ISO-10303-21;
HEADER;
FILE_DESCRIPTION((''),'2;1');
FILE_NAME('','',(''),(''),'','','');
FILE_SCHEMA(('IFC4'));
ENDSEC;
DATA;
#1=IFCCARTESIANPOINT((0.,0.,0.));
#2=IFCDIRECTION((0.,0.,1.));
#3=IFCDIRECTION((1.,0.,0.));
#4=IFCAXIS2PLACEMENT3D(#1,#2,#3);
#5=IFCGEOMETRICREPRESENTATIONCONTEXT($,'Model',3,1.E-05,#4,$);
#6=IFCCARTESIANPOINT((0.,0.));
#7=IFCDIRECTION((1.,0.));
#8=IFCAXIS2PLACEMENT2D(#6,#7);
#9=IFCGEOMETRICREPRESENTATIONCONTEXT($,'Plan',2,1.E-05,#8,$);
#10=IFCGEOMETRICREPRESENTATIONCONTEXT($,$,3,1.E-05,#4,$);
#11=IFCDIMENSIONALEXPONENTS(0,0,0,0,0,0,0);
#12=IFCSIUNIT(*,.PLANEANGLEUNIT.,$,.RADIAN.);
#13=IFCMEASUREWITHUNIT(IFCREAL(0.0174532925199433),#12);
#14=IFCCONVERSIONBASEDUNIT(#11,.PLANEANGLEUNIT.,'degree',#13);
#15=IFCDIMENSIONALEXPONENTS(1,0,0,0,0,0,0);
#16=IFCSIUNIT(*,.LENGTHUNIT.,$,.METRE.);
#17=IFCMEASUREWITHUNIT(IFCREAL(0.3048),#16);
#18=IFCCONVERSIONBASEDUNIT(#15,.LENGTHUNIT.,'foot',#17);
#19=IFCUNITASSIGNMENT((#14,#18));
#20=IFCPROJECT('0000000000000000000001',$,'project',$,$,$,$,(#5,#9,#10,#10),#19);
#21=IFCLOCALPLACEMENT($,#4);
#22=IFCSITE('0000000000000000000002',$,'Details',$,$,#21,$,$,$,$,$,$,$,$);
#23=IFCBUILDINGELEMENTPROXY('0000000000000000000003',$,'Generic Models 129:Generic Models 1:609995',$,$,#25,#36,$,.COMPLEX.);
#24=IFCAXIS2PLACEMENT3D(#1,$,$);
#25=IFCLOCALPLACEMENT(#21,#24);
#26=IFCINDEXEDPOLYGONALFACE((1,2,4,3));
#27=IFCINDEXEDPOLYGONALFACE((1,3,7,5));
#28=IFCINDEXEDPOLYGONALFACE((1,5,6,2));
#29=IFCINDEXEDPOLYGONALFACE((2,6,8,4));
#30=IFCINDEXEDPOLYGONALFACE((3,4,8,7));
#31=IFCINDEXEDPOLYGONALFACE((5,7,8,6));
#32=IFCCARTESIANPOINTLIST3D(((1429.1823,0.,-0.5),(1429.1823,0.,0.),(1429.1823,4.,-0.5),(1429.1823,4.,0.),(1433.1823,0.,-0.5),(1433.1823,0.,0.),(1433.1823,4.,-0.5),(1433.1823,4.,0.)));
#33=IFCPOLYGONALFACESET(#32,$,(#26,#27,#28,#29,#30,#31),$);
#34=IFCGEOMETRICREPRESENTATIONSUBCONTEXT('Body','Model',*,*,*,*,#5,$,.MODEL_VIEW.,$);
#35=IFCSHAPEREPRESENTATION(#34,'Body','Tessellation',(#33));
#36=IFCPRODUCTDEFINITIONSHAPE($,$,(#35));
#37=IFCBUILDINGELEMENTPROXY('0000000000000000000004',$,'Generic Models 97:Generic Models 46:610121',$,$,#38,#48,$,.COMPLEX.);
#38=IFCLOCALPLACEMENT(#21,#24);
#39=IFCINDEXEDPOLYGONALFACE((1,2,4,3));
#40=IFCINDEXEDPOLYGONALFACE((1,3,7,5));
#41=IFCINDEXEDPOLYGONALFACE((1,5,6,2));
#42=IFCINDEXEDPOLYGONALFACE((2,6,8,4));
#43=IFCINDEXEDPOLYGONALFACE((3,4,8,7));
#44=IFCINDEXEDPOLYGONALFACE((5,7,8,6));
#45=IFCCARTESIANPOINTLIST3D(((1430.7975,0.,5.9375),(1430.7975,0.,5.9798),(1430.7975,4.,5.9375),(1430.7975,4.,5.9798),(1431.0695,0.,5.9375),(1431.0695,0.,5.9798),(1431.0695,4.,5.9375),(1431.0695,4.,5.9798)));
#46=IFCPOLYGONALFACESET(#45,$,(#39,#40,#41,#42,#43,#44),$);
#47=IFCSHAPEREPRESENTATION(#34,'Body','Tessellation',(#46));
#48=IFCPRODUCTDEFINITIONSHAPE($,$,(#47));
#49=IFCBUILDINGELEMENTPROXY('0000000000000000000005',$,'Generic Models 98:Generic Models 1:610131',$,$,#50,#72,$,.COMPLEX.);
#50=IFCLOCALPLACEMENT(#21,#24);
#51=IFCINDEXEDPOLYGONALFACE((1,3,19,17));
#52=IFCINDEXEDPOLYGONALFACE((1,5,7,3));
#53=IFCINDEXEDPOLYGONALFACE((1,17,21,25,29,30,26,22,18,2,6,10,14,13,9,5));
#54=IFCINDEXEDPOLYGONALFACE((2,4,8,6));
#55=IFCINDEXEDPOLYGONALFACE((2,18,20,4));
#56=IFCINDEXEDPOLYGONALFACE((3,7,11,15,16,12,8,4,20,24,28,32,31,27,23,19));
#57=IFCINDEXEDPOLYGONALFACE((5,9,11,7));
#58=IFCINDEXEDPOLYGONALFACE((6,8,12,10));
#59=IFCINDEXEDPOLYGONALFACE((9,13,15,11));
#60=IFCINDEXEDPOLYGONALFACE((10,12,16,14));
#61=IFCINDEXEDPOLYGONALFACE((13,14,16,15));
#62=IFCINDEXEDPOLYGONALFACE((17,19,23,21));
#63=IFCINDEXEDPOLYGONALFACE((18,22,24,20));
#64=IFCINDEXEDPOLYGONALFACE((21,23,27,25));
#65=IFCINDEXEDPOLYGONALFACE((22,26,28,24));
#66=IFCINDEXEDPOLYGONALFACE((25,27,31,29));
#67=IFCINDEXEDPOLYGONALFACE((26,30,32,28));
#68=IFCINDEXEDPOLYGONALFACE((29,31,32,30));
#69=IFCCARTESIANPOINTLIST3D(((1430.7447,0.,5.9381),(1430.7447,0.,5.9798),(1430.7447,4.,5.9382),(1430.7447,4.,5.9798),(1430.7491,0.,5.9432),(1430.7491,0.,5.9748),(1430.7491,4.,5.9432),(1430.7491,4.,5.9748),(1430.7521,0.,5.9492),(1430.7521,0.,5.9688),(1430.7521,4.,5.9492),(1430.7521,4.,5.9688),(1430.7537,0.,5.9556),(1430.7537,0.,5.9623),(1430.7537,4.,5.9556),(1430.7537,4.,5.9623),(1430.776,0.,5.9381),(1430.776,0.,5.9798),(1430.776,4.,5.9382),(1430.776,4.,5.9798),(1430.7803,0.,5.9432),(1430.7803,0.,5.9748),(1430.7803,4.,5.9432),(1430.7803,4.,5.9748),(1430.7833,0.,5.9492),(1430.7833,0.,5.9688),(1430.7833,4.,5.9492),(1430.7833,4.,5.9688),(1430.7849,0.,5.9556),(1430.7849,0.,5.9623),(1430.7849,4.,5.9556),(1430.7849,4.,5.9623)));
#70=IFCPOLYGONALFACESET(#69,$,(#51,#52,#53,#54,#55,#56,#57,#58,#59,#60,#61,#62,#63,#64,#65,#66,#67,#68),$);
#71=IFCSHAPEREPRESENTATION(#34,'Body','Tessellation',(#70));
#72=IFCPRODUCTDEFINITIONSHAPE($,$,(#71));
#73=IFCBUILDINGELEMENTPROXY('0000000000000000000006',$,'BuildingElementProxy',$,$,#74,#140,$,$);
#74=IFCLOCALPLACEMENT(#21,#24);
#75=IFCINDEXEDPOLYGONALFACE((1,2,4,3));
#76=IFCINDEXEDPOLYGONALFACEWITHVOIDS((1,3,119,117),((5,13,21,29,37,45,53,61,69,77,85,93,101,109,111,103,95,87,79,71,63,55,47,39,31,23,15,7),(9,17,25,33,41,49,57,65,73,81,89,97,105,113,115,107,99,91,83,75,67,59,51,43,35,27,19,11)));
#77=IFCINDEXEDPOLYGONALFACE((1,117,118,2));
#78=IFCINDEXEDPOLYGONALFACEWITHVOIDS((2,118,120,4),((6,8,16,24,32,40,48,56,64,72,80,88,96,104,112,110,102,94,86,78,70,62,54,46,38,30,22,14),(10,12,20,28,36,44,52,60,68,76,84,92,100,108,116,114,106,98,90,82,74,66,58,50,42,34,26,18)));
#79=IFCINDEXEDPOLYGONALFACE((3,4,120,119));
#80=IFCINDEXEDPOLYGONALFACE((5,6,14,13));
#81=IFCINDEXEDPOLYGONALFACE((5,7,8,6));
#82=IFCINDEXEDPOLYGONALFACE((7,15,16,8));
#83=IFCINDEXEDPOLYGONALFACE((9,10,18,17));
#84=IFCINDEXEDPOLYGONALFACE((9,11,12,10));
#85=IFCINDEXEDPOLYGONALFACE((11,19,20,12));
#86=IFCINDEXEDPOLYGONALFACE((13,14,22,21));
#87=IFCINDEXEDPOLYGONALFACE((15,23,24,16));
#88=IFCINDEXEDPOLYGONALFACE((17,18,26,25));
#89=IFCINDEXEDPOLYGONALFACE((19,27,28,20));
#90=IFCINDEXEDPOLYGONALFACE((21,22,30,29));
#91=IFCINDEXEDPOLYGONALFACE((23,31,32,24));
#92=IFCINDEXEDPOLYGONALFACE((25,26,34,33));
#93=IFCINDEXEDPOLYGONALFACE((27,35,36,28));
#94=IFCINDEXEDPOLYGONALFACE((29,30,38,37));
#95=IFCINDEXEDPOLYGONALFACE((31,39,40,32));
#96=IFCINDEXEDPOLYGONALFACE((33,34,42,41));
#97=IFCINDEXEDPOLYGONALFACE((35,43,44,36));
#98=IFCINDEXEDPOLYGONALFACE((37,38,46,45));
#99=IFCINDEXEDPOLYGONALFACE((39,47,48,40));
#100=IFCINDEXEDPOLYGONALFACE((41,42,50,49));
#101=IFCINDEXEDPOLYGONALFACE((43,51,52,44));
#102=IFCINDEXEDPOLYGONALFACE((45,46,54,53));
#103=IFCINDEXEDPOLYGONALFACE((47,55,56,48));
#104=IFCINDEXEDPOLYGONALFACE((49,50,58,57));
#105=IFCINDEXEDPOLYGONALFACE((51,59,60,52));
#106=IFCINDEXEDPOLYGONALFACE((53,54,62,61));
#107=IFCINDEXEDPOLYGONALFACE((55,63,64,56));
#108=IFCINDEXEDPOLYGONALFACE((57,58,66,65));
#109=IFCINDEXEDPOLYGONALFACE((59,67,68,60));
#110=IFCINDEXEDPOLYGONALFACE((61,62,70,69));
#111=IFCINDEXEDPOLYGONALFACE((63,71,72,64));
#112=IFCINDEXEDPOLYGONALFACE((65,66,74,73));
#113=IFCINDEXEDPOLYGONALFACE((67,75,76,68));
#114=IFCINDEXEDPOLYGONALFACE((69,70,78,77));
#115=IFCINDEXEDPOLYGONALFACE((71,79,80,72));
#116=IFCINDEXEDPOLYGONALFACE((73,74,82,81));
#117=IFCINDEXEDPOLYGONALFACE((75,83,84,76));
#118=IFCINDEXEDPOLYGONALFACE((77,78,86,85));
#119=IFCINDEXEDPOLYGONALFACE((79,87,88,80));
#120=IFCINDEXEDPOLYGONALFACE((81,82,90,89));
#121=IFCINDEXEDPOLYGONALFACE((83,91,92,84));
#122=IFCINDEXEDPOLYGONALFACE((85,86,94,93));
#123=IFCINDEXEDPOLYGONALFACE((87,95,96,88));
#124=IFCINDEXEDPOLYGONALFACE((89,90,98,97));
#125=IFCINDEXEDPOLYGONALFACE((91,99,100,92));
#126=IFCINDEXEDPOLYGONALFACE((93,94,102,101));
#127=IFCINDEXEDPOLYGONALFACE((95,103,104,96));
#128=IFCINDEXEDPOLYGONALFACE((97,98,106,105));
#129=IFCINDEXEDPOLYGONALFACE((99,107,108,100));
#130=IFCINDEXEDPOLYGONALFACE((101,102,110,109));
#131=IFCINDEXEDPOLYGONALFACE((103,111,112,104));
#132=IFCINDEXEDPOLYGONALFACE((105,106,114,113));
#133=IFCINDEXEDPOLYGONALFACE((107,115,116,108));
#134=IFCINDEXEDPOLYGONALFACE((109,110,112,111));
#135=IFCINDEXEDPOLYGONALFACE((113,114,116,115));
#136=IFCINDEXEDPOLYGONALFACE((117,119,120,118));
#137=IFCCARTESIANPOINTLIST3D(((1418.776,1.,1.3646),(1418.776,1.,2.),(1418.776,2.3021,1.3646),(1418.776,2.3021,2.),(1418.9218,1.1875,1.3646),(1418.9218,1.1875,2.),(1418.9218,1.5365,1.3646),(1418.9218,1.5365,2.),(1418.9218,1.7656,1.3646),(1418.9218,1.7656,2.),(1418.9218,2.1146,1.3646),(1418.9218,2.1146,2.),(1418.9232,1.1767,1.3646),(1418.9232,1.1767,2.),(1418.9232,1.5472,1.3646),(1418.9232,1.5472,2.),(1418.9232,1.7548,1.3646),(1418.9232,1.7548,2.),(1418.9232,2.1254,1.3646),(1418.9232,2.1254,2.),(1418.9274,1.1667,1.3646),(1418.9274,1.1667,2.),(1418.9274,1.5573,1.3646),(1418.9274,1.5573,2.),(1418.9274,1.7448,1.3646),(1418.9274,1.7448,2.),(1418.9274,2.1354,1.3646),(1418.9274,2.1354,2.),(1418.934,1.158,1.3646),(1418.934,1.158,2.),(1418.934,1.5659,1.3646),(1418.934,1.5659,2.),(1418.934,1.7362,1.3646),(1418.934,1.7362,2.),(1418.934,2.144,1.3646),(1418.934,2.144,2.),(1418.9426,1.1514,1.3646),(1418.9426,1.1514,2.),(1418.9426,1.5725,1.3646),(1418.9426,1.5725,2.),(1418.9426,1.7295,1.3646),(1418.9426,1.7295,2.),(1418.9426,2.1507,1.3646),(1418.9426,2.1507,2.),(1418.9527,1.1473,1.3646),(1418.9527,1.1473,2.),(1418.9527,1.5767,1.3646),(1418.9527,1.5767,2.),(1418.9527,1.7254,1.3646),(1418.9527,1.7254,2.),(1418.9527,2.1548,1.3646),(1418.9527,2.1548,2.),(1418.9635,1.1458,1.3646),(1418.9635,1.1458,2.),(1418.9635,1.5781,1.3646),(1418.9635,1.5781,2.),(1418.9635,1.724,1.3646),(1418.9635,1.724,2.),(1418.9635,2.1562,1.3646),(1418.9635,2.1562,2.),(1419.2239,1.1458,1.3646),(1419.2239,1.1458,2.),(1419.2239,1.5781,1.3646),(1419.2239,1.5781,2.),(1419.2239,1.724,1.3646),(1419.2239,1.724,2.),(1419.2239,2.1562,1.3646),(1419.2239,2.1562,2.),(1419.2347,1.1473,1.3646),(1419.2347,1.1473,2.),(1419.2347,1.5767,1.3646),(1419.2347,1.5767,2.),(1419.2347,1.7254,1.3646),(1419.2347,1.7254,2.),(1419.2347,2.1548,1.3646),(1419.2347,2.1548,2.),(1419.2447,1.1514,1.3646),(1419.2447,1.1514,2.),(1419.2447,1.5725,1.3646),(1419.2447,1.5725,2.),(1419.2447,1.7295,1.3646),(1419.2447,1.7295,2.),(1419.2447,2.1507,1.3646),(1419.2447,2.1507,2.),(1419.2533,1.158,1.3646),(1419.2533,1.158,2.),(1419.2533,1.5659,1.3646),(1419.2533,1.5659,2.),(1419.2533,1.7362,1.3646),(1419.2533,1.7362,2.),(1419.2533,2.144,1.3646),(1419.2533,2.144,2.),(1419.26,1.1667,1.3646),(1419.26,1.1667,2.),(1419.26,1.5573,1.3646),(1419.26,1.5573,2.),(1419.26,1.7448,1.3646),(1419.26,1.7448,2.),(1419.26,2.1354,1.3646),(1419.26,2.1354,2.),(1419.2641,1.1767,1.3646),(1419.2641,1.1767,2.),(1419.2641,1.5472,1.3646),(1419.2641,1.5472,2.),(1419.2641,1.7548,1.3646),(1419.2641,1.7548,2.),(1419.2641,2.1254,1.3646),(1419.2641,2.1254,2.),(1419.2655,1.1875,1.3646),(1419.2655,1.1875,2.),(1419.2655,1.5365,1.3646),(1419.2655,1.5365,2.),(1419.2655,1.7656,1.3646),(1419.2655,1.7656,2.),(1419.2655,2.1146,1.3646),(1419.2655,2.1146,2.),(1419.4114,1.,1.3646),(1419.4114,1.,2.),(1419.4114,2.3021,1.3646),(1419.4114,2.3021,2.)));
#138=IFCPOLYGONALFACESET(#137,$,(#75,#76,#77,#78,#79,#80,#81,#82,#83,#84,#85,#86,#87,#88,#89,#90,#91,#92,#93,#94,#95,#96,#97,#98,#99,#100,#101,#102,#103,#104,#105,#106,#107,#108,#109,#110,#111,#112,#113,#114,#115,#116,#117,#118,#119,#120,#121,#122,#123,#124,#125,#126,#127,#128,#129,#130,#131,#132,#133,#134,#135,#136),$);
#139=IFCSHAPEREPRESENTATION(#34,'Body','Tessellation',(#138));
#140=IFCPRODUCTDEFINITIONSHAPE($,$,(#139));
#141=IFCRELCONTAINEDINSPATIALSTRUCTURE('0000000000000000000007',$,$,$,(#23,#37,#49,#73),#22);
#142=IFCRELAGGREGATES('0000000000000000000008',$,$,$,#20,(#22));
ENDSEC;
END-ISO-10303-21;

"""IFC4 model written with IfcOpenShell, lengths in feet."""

from ifc_helpers import new_model, entity, si_unit, converted_unit, frame, origin_with_axes, origin_2d_with_axis, place, context, subcontext, project, spatial, polyline, line, indexed_curve, outline, extrude, element, save


model = new_model("IFC4")

# Units and contexts
model_context = context("Model", 3, precision=1e-05, world=origin_with_axes())
plan_context = context("Plan", 2, precision=1e-05, world=origin_2d_with_axis())
context_of_model = context(None, 3, precision=1e-05, world=origin_with_axes())
body_context = subcontext(model_context, "Body", "Model", "MODEL_VIEW")
ifc_project = project(units=[converted_unit("PLANEANGLEUNIT", "degree", entity("IfcReal", 0.0174532925199433), si_unit("PLANEANGLEUNIT", "RADIAN"), dimensions=[0, 0, 0, 0, 0, 0, 0]), converted_unit("LENGTHUNIT", "foot", entity("IfcReal", 0.3048), si_unit("LENGTHUNIT", "METRE"), dimensions=[1, 0, 0, 0, 0, 0, 0])], contexts=[model_context, plan_context, context_of_model, context_of_model])

# Site
site_placement = place(None, origin_with_axes())
site = spatial("IfcSite", under=ifc_project, at=site_placement, Name="Details")

# Building element proxies
proxy_1_placement = place(site_placement, frame((1429.1823, 4.0, -0.5), z_axis=(0.0, -1.0, 0.0), x_axis=(0.0, 0.0, 1.0)))
element("IfcBuildingElementProxy", 1, at=proxy_1_placement, inside=site, Name="Generic Models 129:Generic Models 1:609995", PredefinedType="COMPLEX", context=body_context, shape_type="SweptSolid", body=[
    extrude(outline(polyline([(-0.25, -2.0), (0.25, -2.0), (0.25, 2.0), (-0.25, 2.0), (-0.25, -2.0)])), frame((0.25, -2.0, 0.0), z_axis=(0.0, 0.0, -1.0), x_axis=(-1.0, 0.0, 0.0)), (0.0, 0.0, -1.0), 4.0),
])
proxy_2_placement = place(site_placement, frame((1430.7975, 4.0, 5.9375), z_axis=(0.0, -1.0, 0.0), x_axis=(0.0, 0.0, 1.0)))
element("IfcBuildingElementProxy", 2, at=proxy_2_placement, inside=site, Name="Generic Models 97:Generic Models 46:610121", PredefinedType="COMPLEX", context=body_context, shape_type="SweptSolid", body=[
    extrude(outline(polyline([(-0.0212, -0.136), (0.0212, -0.136), (0.0212, 0.136), (-0.0212, 0.136), (-0.0212, -0.136)])), frame((0.0212, -0.136, 0.0), z_axis=(0.0, 0.0, -1.0), x_axis=(-1.0, 0.0, 0.0)), (0.0, 0.0, -1.0), 4.0),
])
proxy_3_placement = place(site_placement, frame((1430.7849, 3.847, 5.9382), z_axis=(0.0, 1.0, 0.0), x_axis=(0.0, 0.0, 1.0)))
element("IfcBuildingElementProxy", 3, at=proxy_3_placement, inside=site, Name="Generic Models 98:Generic Models 1:610131", PredefinedType="COMPLEX", context=body_context, shape_type="SweptSolid", body=[
    extrude(outline(indexed_curve([(0.0115, 0.0043), (0.0166, 0.0), (0.0226, -0.003), (0.0291, -0.0045), (0.0039, -0.023), (-0.0026, -0.0215), (-0.0086, -0.0185), (-0.0137, -0.0142), (-0.0176, -0.0088), (-0.0202, -0.0026), (-0.0213, 0.004), (-0.0207, 0.0106), (0.0045, 0.0291), (0.0039, 0.0224), (0.005, 0.0159), (0.0076, 0.0097)], segments=[line(12, 11), line(11, 10), line(10, 9), line(9, 8), line(8, 7), line(7, 6), line(6, 5), line(5, 4), line(4, 3), line(3, 2), line(2, 1), line(1, 16), line(16, 15), line(15, 14), line(14, 13), line(13, 12)], self_intersect=False)), frame((0.0208, -0.0194, 0.153), z_axis=(0.0, 0.0, -1.0), x_axis=(0.591192, -0.806531, 0.000001)), (-0.000001, 0.0, 1.0), 4.0),
])
proxy_4_placement = place(site_placement, frame((1419.0936, 2.3021, 1.3646), z_axis=(0.0, 0.0, 1.0), x_axis=(0.0, 1.0, 0.0)))
element("IfcBuildingElementProxy", 4, at=proxy_4_placement, inside=site, Name="BuildingElementProxy", context=body_context, shape_type="SweptSolid", body=[
    extrude(outline(indexed_curve([(-0.3177, -0.651), (0.3177, -0.651), (0.3177, 0.651), (-0.3177, 0.651), (0.1719, -0.1146), (0.1719, -0.4635), (0.1705, -0.4743), (0.1663, -0.4844), (0.1597, -0.493), (0.151, -0.4996), (0.141, -0.5038), (0.1302, -0.5052), (-0.1302, -0.5052), (-0.141, -0.5038), (-0.151, -0.4996), (-0.1597, -0.493), (-0.1663, -0.4844), (-0.1705, -0.4743), (-0.1719, -0.4635), (-0.1719, -0.1146), (-0.1705, -0.1038), (-0.1663, -0.0938), (-0.1597, -0.0851), (-0.151, -0.0785), (-0.141, -0.0743), (-0.1302, -0.0729), (0.1302, -0.0729), (0.141, -0.0743), (0.151, -0.0785), (0.1597, -0.0851), (0.1663, -0.0938), (0.1705, -0.1038), (0.151, 0.0785), (0.141, 0.0743), (0.1302, 0.0729), (-0.1302, 0.0729), (-0.141, 0.0743), (-0.151, 0.0785), (-0.1597, 0.0851), (-0.1663, 0.0937), (-0.1705, 0.1038), (-0.1719, 0.1146), (-0.1719, 0.4635), (-0.1705, 0.4743), (-0.1663, 0.4844), (-0.1597, 0.493), (-0.151, 0.4996), (-0.141, 0.5038), (-0.1302, 0.5052), (0.1302, 0.5052), (0.141, 0.5038), (0.151, 0.4996), (0.1597, 0.493), (0.1663, 0.4844), (0.1705, 0.4743), (0.1719, 0.4635), (0.1719, 0.1146), (0.1705, 0.1038), (0.1663, 0.0937), (0.1597, 0.0851)], segments=[line(4, 3), line(3, 2), line(2, 1), line(1, 4)], self_intersect=False), holes=[indexed_curve([(-0.3177, -0.651), (0.3177, -0.651), (0.3177, 0.651), (-0.3177, 0.651), (0.1719, -0.1146), (0.1719, -0.4635), (0.1705, -0.4743), (0.1663, -0.4844), (0.1597, -0.493), (0.151, -0.4996), (0.141, -0.5038), (0.1302, -0.5052), (-0.1302, -0.5052), (-0.141, -0.5038), (-0.151, -0.4996), (-0.1597, -0.493), (-0.1663, -0.4844), (-0.1705, -0.4743), (-0.1719, -0.4635), (-0.1719, -0.1146), (-0.1705, -0.1038), (-0.1663, -0.0938), (-0.1597, -0.0851), (-0.151, -0.0785), (-0.141, -0.0743), (-0.1302, -0.0729), (0.1302, -0.0729), (0.141, -0.0743), (0.151, -0.0785), (0.1597, -0.0851), (0.1663, -0.0938), (0.1705, -0.1038), (0.151, 0.0785), (0.141, 0.0743), (0.1302, 0.0729), (-0.1302, 0.0729), (-0.141, 0.0743), (-0.151, 0.0785), (-0.1597, 0.0851), (-0.1663, 0.0937), (-0.1705, 0.1038), (-0.1719, 0.1146), (-0.1719, 0.4635), (-0.1705, 0.4743), (-0.1663, 0.4844), (-0.1597, 0.493), (-0.151, 0.4996), (-0.141, 0.5038), (-0.1302, 0.5052), (0.1302, 0.5052), (0.141, 0.5038), (0.151, 0.4996), (0.1597, 0.493), (0.1663, 0.4844), (0.1705, 0.4743), (0.1719, 0.4635), (0.1719, 0.1146), (0.1705, 0.1038), (0.1663, 0.0937), (0.1597, 0.0851)], segments=[line(20, 19), line(19, 18), line(18, 17), line(17, 16), line(16, 15), line(15, 14), line(14, 13), line(13, 12), line(12, 11), line(11, 10), line(10, 9), line(9, 8), line(8, 7), line(7, 6), line(6, 5), line(5, 32), line(32, 31), line(31, 30), line(30, 29), line(29, 28), line(28, 27), line(27, 26), line(26, 25), line(25, 24), line(24, 23), line(23, 22), line(22, 21), line(21, 20)], self_intersect=False), indexed_curve([(-0.3177, -0.651), (0.3177, -0.651), (0.3177, 0.651), (-0.3177, 0.651), (0.1719, -0.1146), (0.1719, -0.4635), (0.1705, -0.4743), (0.1663, -0.4844), (0.1597, -0.493), (0.151, -0.4996), (0.141, -0.5038), (0.1302, -0.5052), (-0.1302, -0.5052), (-0.141, -0.5038), (-0.151, -0.4996), (-0.1597, -0.493), (-0.1663, -0.4844), (-0.1705, -0.4743), (-0.1719, -0.4635), (-0.1719, -0.1146), (-0.1705, -0.1038), (-0.1663, -0.0938), (-0.1597, -0.0851), (-0.151, -0.0785), (-0.141, -0.0743), (-0.1302, -0.0729), (0.1302, -0.0729), (0.141, -0.0743), (0.151, -0.0785), (0.1597, -0.0851), (0.1663, -0.0938), (0.1705, -0.1038), (0.151, 0.0785), (0.141, 0.0743), (0.1302, 0.0729), (-0.1302, 0.0729), (-0.141, 0.0743), (-0.151, 0.0785), (-0.1597, 0.0851), (-0.1663, 0.0937), (-0.1705, 0.1038), (-0.1719, 0.1146), (-0.1719, 0.4635), (-0.1705, 0.4743), (-0.1663, 0.4844), (-0.1597, 0.493), (-0.151, 0.4996), (-0.141, 0.5038), (-0.1302, 0.5052), (0.1302, 0.5052), (0.141, 0.5038), (0.151, 0.4996), (0.1597, 0.493), (0.1663, 0.4844), (0.1705, 0.4743), (0.1719, 0.4635), (0.1719, 0.1146), (0.1705, 0.1038), (0.1663, 0.0937), (0.1597, 0.0851)], segments=[line(44, 43), line(43, 42), line(42, 41), line(41, 40), line(40, 39), line(39, 38), line(38, 37), line(37, 36), line(36, 35), line(35, 34), line(34, 33), line(33, 60), line(60, 59), line(59, 58), line(58, 57), line(57, 56), line(56, 55), line(55, 54), line(54, 53), line(53, 52), line(52, 51), line(51, 50), line(50, 49), line(49, 48), line(48, 47), line(47, 46), line(46, 45), line(45, 44)], self_intersect=False)]), frame((-0.651, 0.0, 0.0), z_axis=(0.0, 0.0, 1.0), x_axis=(0.0, -1.0, 0.0)), (0.0, 0.0, 1.0), 0.6354),
])

save(model, "model.ifc")
